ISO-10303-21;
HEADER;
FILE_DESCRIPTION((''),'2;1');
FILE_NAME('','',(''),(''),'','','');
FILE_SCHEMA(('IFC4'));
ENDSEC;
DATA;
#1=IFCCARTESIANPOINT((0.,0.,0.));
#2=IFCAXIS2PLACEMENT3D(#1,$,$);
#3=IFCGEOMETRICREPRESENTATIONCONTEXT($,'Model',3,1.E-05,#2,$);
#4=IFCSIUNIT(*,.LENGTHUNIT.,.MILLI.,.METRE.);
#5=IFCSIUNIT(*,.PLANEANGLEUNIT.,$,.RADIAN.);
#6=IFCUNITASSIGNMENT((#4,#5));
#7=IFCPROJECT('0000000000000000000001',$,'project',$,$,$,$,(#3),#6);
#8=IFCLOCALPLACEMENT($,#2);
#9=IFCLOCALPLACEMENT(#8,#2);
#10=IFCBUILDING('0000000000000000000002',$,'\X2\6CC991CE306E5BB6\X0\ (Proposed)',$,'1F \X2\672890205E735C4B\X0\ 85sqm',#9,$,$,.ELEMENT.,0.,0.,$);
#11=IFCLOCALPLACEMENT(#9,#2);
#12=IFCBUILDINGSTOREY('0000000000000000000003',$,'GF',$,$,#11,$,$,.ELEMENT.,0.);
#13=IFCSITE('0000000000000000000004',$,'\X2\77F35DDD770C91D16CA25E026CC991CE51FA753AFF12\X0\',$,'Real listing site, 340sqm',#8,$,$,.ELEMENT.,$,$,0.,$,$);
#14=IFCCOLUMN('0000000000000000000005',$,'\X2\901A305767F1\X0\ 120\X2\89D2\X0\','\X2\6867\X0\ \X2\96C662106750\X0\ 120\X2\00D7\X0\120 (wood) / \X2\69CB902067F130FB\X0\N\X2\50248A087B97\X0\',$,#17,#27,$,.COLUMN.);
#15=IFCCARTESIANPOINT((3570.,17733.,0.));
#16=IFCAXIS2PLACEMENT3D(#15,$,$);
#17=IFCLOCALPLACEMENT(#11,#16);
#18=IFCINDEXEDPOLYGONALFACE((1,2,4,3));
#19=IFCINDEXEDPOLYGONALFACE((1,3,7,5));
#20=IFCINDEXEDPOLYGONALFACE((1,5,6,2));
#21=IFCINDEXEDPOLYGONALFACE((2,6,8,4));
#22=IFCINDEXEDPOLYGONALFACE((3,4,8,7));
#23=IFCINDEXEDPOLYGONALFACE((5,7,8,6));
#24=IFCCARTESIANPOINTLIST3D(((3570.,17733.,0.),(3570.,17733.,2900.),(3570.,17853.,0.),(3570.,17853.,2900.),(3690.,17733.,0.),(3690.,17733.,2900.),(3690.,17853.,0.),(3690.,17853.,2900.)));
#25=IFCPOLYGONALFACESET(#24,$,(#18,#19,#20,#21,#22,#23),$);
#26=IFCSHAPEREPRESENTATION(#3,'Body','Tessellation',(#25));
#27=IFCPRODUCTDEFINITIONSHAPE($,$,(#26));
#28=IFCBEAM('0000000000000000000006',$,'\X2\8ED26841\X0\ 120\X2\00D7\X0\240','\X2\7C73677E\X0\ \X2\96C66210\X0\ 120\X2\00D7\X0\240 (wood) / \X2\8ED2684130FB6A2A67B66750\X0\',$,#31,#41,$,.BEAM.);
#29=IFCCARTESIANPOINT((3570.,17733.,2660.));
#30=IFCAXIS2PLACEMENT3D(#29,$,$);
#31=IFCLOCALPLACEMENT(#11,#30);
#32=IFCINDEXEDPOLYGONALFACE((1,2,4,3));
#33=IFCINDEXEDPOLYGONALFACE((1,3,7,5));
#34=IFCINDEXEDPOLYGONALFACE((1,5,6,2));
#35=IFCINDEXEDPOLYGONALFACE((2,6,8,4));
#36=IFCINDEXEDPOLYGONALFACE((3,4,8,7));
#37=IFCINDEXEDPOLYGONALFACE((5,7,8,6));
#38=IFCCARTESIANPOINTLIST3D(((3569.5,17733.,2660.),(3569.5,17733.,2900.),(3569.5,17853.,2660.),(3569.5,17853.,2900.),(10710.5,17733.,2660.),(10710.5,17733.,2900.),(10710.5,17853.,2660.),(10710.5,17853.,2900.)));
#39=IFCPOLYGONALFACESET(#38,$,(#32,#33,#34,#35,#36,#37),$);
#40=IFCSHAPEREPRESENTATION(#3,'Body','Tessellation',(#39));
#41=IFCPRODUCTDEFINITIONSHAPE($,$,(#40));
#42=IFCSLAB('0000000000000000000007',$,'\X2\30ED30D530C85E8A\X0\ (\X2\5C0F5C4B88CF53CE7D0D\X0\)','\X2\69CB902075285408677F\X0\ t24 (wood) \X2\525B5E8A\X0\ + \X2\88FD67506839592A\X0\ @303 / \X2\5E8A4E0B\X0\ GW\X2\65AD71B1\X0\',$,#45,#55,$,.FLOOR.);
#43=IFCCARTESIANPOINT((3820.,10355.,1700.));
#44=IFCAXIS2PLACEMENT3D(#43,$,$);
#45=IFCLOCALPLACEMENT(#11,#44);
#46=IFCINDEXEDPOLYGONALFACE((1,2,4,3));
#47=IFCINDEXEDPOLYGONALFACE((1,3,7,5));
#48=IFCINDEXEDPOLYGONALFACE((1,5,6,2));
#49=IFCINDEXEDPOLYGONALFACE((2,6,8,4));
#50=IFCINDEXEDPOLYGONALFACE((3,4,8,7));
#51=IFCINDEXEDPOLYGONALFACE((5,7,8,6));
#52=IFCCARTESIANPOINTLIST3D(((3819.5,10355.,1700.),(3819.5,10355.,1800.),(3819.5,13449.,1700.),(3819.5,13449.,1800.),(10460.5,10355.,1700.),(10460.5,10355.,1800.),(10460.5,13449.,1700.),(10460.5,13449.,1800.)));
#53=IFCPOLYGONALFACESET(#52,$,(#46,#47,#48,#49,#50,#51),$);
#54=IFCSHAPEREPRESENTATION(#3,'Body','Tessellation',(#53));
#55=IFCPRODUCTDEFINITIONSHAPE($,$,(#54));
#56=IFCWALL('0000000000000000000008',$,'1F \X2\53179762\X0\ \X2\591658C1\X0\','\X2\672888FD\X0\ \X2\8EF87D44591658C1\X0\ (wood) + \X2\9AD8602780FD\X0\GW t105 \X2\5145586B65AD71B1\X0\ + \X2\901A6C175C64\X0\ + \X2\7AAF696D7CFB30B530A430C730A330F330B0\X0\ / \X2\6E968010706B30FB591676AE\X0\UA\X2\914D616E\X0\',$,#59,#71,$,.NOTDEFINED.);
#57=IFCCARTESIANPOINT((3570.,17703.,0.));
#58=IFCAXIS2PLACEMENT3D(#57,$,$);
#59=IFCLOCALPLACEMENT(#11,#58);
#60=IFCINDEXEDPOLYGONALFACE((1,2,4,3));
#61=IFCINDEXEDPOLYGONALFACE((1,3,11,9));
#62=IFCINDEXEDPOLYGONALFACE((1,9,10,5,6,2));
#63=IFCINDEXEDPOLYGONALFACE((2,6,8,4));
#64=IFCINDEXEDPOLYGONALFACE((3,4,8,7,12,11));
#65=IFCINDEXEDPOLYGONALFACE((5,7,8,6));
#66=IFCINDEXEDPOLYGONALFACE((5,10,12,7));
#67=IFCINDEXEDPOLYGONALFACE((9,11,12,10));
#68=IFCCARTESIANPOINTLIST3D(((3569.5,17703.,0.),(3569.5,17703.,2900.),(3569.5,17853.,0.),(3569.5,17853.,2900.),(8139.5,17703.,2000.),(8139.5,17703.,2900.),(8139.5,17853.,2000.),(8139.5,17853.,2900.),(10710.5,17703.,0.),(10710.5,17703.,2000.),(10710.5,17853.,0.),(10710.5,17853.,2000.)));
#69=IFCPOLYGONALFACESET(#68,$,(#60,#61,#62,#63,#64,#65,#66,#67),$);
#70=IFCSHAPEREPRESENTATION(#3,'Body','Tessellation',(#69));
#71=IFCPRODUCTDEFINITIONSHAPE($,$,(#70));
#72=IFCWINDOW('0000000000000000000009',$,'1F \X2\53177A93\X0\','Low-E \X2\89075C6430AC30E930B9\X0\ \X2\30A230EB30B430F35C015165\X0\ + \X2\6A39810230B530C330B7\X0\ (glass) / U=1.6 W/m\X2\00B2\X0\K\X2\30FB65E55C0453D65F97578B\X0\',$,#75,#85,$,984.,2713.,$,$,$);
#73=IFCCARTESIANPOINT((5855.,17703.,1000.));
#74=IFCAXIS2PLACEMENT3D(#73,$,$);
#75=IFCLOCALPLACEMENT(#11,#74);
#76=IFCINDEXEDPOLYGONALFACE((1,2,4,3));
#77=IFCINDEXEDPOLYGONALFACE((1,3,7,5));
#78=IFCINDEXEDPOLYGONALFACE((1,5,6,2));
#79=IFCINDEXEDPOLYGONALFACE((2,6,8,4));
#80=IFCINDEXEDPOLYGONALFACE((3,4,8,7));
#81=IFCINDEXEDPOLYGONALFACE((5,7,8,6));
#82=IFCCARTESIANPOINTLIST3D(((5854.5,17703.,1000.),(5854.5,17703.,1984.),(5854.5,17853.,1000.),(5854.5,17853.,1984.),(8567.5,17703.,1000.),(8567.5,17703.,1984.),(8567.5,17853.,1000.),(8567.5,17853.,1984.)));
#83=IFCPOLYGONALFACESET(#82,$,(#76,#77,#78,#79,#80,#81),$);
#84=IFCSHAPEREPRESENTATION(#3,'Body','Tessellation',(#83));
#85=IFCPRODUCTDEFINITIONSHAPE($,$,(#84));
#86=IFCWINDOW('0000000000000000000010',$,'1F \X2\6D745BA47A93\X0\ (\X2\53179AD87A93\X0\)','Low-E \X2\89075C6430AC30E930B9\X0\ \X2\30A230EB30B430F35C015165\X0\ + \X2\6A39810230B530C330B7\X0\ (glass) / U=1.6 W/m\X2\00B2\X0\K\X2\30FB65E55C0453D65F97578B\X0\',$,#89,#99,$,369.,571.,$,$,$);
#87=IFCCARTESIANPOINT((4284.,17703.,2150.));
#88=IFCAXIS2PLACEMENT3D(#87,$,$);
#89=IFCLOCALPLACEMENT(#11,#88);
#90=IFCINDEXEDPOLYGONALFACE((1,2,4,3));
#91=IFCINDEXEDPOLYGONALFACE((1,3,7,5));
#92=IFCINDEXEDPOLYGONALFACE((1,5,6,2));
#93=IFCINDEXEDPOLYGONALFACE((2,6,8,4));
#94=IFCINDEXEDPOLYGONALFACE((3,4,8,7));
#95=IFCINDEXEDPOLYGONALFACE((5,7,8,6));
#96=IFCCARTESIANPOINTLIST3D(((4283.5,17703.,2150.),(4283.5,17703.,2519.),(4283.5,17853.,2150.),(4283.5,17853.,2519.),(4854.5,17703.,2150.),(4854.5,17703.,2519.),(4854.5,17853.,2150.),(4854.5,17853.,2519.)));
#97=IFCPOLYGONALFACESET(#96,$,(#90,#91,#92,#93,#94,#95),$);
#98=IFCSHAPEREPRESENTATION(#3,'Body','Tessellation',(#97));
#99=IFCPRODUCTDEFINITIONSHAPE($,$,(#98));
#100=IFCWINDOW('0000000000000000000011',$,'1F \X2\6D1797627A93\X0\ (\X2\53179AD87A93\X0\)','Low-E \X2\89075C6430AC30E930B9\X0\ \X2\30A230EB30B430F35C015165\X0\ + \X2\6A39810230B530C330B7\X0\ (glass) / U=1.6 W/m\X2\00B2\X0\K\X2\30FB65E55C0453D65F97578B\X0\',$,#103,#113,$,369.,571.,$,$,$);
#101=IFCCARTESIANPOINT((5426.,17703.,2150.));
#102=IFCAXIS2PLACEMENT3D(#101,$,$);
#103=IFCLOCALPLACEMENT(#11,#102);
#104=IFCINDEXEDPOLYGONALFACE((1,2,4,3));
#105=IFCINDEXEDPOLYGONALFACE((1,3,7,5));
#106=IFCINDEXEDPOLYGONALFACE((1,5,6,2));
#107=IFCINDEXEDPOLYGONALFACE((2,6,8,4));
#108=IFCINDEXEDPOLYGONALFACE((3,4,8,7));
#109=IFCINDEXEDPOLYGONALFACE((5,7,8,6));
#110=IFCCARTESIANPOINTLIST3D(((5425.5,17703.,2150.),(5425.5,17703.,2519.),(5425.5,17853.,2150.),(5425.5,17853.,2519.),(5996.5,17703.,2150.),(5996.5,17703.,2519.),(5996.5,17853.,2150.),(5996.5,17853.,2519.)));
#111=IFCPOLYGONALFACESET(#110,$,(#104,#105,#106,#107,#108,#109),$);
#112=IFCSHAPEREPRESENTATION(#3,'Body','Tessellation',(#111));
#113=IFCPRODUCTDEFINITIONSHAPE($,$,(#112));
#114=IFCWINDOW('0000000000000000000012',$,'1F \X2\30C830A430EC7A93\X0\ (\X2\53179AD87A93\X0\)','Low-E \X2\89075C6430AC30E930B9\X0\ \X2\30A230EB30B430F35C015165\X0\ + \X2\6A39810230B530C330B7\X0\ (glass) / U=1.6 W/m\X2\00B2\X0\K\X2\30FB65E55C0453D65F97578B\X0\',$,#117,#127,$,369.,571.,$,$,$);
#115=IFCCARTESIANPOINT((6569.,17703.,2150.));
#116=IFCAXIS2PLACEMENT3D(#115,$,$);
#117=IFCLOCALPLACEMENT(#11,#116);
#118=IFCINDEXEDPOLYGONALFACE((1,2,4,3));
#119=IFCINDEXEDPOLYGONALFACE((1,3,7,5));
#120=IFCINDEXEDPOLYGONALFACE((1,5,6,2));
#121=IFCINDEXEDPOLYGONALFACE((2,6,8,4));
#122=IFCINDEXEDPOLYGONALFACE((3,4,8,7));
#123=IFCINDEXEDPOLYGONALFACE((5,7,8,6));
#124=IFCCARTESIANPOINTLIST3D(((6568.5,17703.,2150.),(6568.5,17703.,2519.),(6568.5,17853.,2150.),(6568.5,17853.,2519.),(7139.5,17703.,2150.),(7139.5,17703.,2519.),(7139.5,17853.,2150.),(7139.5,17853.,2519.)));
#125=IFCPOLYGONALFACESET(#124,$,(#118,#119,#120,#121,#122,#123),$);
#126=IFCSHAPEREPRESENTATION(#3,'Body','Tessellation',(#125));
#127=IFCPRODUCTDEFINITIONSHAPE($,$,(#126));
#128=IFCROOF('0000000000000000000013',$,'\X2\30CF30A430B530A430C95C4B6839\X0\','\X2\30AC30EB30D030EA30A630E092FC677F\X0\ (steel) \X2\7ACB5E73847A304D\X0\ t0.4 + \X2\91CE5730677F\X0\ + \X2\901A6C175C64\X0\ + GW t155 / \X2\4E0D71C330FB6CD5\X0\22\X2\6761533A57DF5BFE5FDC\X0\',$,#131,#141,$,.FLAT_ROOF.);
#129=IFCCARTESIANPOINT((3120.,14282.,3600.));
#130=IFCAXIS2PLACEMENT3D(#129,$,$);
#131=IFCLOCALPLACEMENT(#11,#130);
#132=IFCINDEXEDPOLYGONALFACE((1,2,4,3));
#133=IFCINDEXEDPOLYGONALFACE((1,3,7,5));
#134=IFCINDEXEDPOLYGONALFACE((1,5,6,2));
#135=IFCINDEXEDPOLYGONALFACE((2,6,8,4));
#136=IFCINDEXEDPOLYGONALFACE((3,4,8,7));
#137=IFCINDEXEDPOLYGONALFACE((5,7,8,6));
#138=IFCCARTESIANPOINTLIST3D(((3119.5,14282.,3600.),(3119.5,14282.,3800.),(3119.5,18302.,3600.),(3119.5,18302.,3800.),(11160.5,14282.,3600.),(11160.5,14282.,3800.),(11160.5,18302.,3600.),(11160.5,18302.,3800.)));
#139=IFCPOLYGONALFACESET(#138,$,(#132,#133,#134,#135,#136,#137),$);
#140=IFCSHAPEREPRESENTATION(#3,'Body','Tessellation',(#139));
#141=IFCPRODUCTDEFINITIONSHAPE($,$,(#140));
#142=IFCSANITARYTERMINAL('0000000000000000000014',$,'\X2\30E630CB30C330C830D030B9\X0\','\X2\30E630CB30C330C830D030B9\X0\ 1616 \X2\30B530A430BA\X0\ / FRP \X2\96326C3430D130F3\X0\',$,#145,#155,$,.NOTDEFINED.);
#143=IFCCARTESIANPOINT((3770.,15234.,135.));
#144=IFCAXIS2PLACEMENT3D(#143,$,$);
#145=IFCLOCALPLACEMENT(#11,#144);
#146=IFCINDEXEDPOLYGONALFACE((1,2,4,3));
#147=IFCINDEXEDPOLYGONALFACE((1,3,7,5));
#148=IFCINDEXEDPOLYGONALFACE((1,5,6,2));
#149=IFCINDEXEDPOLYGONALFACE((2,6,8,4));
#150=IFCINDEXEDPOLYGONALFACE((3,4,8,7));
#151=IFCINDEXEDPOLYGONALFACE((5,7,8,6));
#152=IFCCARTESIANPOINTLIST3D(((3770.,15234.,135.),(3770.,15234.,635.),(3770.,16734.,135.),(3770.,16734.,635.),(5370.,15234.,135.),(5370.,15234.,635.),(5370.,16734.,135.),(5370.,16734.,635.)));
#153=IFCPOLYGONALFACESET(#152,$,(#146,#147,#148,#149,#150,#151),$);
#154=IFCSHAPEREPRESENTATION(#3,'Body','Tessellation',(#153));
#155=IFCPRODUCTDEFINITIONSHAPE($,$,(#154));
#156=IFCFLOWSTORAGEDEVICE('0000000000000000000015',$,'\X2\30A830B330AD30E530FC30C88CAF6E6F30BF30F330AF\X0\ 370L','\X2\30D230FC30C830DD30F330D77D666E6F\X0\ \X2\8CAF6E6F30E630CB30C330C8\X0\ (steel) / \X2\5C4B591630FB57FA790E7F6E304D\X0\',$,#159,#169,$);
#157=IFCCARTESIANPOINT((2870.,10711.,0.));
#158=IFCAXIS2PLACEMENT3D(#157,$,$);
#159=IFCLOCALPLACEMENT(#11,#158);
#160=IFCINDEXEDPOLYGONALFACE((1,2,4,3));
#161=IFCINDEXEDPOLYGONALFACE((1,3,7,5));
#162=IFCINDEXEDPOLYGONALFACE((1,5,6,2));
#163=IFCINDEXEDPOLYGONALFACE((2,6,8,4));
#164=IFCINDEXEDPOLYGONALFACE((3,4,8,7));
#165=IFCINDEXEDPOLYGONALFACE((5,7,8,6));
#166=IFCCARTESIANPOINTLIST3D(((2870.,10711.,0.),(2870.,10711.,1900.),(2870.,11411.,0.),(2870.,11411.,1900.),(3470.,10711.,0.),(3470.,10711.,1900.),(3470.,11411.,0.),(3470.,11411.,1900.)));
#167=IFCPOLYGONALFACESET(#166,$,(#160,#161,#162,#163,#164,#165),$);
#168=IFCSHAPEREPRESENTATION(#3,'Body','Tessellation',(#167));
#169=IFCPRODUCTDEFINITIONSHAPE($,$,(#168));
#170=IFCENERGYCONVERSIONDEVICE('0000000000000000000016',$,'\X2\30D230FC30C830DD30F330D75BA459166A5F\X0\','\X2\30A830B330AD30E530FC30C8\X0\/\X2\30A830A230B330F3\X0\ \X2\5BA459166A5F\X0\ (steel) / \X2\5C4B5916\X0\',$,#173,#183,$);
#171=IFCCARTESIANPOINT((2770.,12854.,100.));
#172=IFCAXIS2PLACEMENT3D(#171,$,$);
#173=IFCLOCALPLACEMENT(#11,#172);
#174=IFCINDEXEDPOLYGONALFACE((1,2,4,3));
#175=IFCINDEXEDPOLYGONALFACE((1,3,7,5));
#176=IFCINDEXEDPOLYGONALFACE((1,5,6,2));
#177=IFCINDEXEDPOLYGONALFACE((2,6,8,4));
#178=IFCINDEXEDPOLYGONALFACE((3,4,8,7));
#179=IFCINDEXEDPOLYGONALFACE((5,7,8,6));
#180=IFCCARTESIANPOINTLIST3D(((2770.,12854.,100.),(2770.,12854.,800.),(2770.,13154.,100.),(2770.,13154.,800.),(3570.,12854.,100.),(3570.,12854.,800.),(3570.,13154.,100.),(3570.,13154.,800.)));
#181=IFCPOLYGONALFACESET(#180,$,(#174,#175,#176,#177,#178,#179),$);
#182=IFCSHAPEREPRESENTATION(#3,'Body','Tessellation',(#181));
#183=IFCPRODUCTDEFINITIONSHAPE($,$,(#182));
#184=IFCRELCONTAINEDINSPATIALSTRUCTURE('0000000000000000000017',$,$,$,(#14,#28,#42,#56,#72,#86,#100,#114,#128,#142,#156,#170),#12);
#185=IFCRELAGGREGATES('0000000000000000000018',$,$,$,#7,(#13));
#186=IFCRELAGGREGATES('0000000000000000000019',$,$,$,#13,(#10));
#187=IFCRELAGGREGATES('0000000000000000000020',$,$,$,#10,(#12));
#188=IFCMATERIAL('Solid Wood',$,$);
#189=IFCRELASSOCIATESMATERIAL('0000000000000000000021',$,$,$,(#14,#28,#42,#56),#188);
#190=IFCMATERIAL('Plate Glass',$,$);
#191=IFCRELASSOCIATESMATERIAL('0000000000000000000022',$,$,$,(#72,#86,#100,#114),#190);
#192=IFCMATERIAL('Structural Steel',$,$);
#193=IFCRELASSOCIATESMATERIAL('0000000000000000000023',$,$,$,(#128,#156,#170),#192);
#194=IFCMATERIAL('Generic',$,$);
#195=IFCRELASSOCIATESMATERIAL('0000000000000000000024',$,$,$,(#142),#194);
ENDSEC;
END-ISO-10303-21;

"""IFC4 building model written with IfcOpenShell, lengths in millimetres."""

from ifc_helpers import new_model, si_unit, frame, frame_2d, origin, place, context, project, spatial, rectangle, extrude, material, element, fill, save


model = new_model("IFC4")

# Units and contexts
model_context = context("Model", 3, precision=1e-05, world=origin())
ifc_project = project(units=[si_unit("LENGTHUNIT", "METRE", prefix="MILLI"), si_unit("PLANEANGLEUNIT", "RADIAN")], contexts=[model_context])

# Site, building, storey
site_placement = place(None, origin())
site = spatial("IfcSite", under=ifc_project, at=site_placement, Name="石川県金沢市泉野出町２", ObjectType="Real listing site, 340sqm", CompositionType="ELEMENT", RefElevation=0.0)
building_placement = place(site_placement, origin())
building = spatial("IfcBuilding", under=site, at=building_placement, Name="泉野の家 (Proposed)", ObjectType="1F 木造平屋 85sqm", CompositionType="ELEMENT", ElevationOfRefHeight=0.0, ElevationOfTerrain=0.0)
storey_placement = place(building_placement, origin())
storey = spatial("IfcBuildingStorey", under=building, at=storey_placement, Name="GF", CompositionType="ELEMENT", Elevation=0.0)

# Column
ifc_material_1 = material(Name="Solid Wood")
column_1_placement = place(storey_placement, frame((3570.0, 17733.0, 0.0)))
element("IfcColumn", 1, at=column_1_placement, inside=storey, material=ifc_material_1, Name="通し柱 120角", Description="桧 集成材 120×120 (wood) / 構造柱・N値計算", PredefinedType="COLUMN", context=model_context, shape_type="SweptSolid", body=[
    extrude(rectangle(XDim=120.0, YDim=120.0, at=frame_2d((60.0, 60.0))), frame((3570.0, 17733.0, 0.0)), (0.0, 0.0, 1.0), 2900.0),
])

# Beam
beam_1_placement = place(storey_placement, frame((3570.0, 17733.0, 2660.0)))
element("IfcBeam", 2, at=beam_1_placement, inside=storey, material=ifc_material_1, Name="軒桁 120×240", Description="米松 集成 120×240 (wood) / 軒桁・横架材", PredefinedType="BEAM", context=model_context, shape_type="SweptSolid", body=[
    extrude(rectangle(XDim=7141.0, YDim=120.0, at=frame_2d((3570.0, 60.0))), frame((3570.0, 17733.0, 2660.0)), (0.0, 0.0, 1.0), 240.0),
])

# Slab
slab_placement = place(storey_placement, frame((3820.0, 10355.0, 1700.0)))
element("IfcSlab", 3, at=slab_placement, inside=storey, material=ifc_material_1, Name="ロフト床 (小屋裏収納)", Description="構造用合板 t24 (wood) 剛床 + 製材根太 @303 / 床下 GW断熱", PredefinedType="FLOOR", context=model_context, shape_type="SweptSolid", body=[
    extrude(rectangle(XDim=6641.0, YDim=3094.0, at=frame_2d((3320.0, 1547.0))), frame((3820.0, 10355.0, 1700.0)), (0.0, 0.0, 1.0), 100.0),
])

# Wall, openings, windows
wall_1_placement = place(storey_placement, frame((3570.0, 17703.0, 0.0)))
wall_1 = element("IfcWall", 4, at=wall_1_placement, inside=storey, material=ifc_material_1, Name="1F 北面 外壁", Description="木製 軸組外壁 (wood) + 高性能GW t105 充填断熱 + 通気層 + 窯業系サイディング / 準耐火・外皮UA配慮", PredefinedType="NOTDEFINED", context=model_context, shape_type="SweptSolid", body=[
    extrude(rectangle(XDim=7141.0, YDim=150.0, at=frame_2d((3570.0, 75.0))), frame((3570.0, 17703.0, 0.0)), (0.0, 0.0, 1.0), 2900.0),
])
opening_1_placement = place(storey_placement, frame((5855.0, 17703.0, 1000.0)))
opening_1 = element("IfcOpeningElement", 5, at=opening_1_placement, cuts=wall_1, PredefinedType="NOTDEFINED", context=model_context, shape_type="SweptSolid", body=[
    extrude(rectangle(XDim=2713.0, YDim=150.0, at=frame_2d((1356.0, 75.0))), frame((5855.0, 17703.0, 1000.0)), (0.0, 0.0, 1.0), 984.0),
])
opening_2_placement = place(storey_placement, frame((4284.0, 17703.0, 2150.0)))
opening_2 = element("IfcOpeningElement", 6, at=opening_2_placement, cuts=wall_1, PredefinedType="NOTDEFINED", context=model_context, shape_type="SweptSolid", body=[
    extrude(rectangle(XDim=571.0, YDim=150.0, at=frame_2d((285.0, 75.0))), frame((4284.0, 17703.0, 2150.0)), (0.0, 0.0, 1.0), 369.0),
])
opening_3_placement = place(storey_placement, frame((5426.0, 17703.0, 2150.0)))
opening_3 = element("IfcOpeningElement", 7, at=opening_3_placement, cuts=wall_1, PredefinedType="NOTDEFINED", context=model_context, shape_type="SweptSolid", body=[
    extrude(rectangle(XDim=571.0, YDim=150.0, at=frame_2d((285.0, 75.0))), frame((5426.0, 17703.0, 2150.0)), (0.0, 0.0, 1.0), 369.0),
])
opening_4_placement = place(storey_placement, frame((6569.0, 17703.0, 2150.0)))
opening_4 = element("IfcOpeningElement", 8, at=opening_4_placement, cuts=wall_1, PredefinedType="NOTDEFINED", context=model_context, shape_type="SweptSolid", body=[
    extrude(rectangle(XDim=571.0, YDim=150.0, at=frame_2d((285.0, 75.0))), frame((6569.0, 17703.0, 2150.0)), (0.0, 0.0, 1.0), 369.0),
])
ifc_material_2 = material(Name="Plate Glass")
window_1_placement = place(storey_placement, frame((5855.0, 17703.0, 1000.0)))
window_1 = element("IfcWindow", 9, at=window_1_placement, inside=storey, material=ifc_material_2, Name="1F 北窓", Description="Low-E 複層ガラス アルゴン封入 + 樹脂サッシ (glass) / U=1.6 W/m²K・日射取得型", OverallHeight=984.0, OverallWidth=2713.0, context=model_context, shape_type="SweptSolid", body=[
    extrude(rectangle(XDim=2713.0, YDim=150.0, at=frame_2d((1356.0, 75.0))), frame((5855.0, 17703.0, 1000.0)), (0.0, 0.0, 1.0), 984.0),
])
fill(opening_1, window_1)
window_2_placement = place(storey_placement, frame((4284.0, 17703.0, 2150.0)))
window_2 = element("IfcWindow", 10, at=window_2_placement, inside=storey, material=ifc_material_2, Name="1F 浴室窓 (北高窓)", Description="Low-E 複層ガラス アルゴン封入 + 樹脂サッシ (glass) / U=1.6 W/m²K・日射取得型", OverallHeight=369.0, OverallWidth=571.0, context=model_context, shape_type="SweptSolid", body=[
    extrude(rectangle(XDim=571.0, YDim=150.0, at=frame_2d((285.0, 75.0))), frame((4284.0, 17703.0, 2150.0)), (0.0, 0.0, 1.0), 369.0),
])
fill(opening_2, window_2)
window_3_placement = place(storey_placement, frame((5426.0, 17703.0, 2150.0)))
window_3 = element("IfcWindow", 11, at=window_3_placement, inside=storey, material=ifc_material_2, Name="1F 洗面窓 (北高窓)", Description="Low-E 複層ガラス アルゴン封入 + 樹脂サッシ (glass) / U=1.6 W/m²K・日射取得型", OverallHeight=369.0, OverallWidth=571.0, context=model_context, shape_type="SweptSolid", body=[
    extrude(rectangle(XDim=571.0, YDim=150.0, at=frame_2d((285.0, 75.0))), frame((5426.0, 17703.0, 2150.0)), (0.0, 0.0, 1.0), 369.0),
])
fill(opening_3, window_3)
window_4_placement = place(storey_placement, frame((6569.0, 17703.0, 2150.0)))
window_4 = element("IfcWindow", 12, at=window_4_placement, inside=storey, material=ifc_material_2, Name="1F トイレ窓 (北高窓)", Description="Low-E 複層ガラス アルゴン封入 + 樹脂サッシ (glass) / U=1.6 W/m²K・日射取得型", OverallHeight=369.0, OverallWidth=571.0, context=model_context, shape_type="SweptSolid", body=[
    extrude(rectangle(XDim=571.0, YDim=150.0, at=frame_2d((285.0, 75.0))), frame((6569.0, 17703.0, 2150.0)), (0.0, 0.0, 1.0), 369.0),
])
fill(opening_4, window_4)

# Roof
ifc_material_3 = material(Name="Structural Steel")
roof_placement = place(storey_placement, frame((3120.0, 14282.0, 3600.0)))
element("IfcRoof", 13, at=roof_placement, inside=storey, material=ifc_material_3, Name="ハイサイド屋根", Description="ガルバリウム鋼板 (steel) 立平葺き t0.4 + 野地板 + 通気層 + GW t155 / 不燃・法22条区域対応", PredefinedType="FLAT_ROOF", context=model_context, shape_type="SweptSolid", body=[
    extrude(rectangle(XDim=8041.0, YDim=4020.0, at=frame_2d((4020.0, 2010.0))), frame((3120.0, 14282.0, 3600.0)), (0.0, 0.0, 1.0), 200.0),
])

# Sanitary terminal
ifc_material_4 = material(Name="Generic")
sanitary_terminal_placement = place(storey_placement, frame((3770.0, 15234.0, 135.0)))
element("IfcSanitaryTerminal", 14, at=sanitary_terminal_placement, inside=storey, material=ifc_material_4, Name="ユニットバス", Description="ユニットバス 1616 サイズ / FRP 防水パン", PredefinedType="NOTDEFINED", context=model_context, shape_type="SweptSolid", body=[
    extrude(rectangle(XDim=1600.0, YDim=1500.0, at=frame_2d((800.0, 750.0))), frame((3770.0, 15234.0, 135.0)), (0.0, 0.0, 1.0), 500.0),
])

# Flow storage device
flow_storage_device_placement = place(storey_placement, frame((2870.0, 10711.0, 0.0)))
element("IfcFlowStorageDevice", 15, at=flow_storage_device_placement, inside=storey, material=ifc_material_3, Name="エコキュート貯湯タンク 370L", Description="ヒートポンプ給湯 貯湯ユニット (steel) / 屋外・基礎置き", context=model_context, shape_type="SweptSolid", body=[
    extrude(rectangle(XDim=600.0, YDim=700.0, at=frame_2d((300.0, 350.0))), frame((2870.0, 10711.0, 0.0)), (0.0, 0.0, 1.0), 1900.0),
])

# Energy conversion device
energy_conversion_device_placement = place(storey_placement, frame((2770.0, 12854.0, 100.0)))
element("IfcEnergyConversionDevice", 16, at=energy_conversion_device_placement, inside=storey, material=ifc_material_3, Name="ヒートポンプ室外機", Description="エコキュート/エアコン 室外機 (steel) / 屋外", context=model_context, shape_type="SweptSolid", body=[
    extrude(rectangle(XDim=800.0, YDim=300.0, at=frame_2d((400.0, 150.0))), frame((2770.0, 12854.0, 100.0)), (0.0, 0.0, 1.0), 700.0),
])

save(model, "model.ifc")
